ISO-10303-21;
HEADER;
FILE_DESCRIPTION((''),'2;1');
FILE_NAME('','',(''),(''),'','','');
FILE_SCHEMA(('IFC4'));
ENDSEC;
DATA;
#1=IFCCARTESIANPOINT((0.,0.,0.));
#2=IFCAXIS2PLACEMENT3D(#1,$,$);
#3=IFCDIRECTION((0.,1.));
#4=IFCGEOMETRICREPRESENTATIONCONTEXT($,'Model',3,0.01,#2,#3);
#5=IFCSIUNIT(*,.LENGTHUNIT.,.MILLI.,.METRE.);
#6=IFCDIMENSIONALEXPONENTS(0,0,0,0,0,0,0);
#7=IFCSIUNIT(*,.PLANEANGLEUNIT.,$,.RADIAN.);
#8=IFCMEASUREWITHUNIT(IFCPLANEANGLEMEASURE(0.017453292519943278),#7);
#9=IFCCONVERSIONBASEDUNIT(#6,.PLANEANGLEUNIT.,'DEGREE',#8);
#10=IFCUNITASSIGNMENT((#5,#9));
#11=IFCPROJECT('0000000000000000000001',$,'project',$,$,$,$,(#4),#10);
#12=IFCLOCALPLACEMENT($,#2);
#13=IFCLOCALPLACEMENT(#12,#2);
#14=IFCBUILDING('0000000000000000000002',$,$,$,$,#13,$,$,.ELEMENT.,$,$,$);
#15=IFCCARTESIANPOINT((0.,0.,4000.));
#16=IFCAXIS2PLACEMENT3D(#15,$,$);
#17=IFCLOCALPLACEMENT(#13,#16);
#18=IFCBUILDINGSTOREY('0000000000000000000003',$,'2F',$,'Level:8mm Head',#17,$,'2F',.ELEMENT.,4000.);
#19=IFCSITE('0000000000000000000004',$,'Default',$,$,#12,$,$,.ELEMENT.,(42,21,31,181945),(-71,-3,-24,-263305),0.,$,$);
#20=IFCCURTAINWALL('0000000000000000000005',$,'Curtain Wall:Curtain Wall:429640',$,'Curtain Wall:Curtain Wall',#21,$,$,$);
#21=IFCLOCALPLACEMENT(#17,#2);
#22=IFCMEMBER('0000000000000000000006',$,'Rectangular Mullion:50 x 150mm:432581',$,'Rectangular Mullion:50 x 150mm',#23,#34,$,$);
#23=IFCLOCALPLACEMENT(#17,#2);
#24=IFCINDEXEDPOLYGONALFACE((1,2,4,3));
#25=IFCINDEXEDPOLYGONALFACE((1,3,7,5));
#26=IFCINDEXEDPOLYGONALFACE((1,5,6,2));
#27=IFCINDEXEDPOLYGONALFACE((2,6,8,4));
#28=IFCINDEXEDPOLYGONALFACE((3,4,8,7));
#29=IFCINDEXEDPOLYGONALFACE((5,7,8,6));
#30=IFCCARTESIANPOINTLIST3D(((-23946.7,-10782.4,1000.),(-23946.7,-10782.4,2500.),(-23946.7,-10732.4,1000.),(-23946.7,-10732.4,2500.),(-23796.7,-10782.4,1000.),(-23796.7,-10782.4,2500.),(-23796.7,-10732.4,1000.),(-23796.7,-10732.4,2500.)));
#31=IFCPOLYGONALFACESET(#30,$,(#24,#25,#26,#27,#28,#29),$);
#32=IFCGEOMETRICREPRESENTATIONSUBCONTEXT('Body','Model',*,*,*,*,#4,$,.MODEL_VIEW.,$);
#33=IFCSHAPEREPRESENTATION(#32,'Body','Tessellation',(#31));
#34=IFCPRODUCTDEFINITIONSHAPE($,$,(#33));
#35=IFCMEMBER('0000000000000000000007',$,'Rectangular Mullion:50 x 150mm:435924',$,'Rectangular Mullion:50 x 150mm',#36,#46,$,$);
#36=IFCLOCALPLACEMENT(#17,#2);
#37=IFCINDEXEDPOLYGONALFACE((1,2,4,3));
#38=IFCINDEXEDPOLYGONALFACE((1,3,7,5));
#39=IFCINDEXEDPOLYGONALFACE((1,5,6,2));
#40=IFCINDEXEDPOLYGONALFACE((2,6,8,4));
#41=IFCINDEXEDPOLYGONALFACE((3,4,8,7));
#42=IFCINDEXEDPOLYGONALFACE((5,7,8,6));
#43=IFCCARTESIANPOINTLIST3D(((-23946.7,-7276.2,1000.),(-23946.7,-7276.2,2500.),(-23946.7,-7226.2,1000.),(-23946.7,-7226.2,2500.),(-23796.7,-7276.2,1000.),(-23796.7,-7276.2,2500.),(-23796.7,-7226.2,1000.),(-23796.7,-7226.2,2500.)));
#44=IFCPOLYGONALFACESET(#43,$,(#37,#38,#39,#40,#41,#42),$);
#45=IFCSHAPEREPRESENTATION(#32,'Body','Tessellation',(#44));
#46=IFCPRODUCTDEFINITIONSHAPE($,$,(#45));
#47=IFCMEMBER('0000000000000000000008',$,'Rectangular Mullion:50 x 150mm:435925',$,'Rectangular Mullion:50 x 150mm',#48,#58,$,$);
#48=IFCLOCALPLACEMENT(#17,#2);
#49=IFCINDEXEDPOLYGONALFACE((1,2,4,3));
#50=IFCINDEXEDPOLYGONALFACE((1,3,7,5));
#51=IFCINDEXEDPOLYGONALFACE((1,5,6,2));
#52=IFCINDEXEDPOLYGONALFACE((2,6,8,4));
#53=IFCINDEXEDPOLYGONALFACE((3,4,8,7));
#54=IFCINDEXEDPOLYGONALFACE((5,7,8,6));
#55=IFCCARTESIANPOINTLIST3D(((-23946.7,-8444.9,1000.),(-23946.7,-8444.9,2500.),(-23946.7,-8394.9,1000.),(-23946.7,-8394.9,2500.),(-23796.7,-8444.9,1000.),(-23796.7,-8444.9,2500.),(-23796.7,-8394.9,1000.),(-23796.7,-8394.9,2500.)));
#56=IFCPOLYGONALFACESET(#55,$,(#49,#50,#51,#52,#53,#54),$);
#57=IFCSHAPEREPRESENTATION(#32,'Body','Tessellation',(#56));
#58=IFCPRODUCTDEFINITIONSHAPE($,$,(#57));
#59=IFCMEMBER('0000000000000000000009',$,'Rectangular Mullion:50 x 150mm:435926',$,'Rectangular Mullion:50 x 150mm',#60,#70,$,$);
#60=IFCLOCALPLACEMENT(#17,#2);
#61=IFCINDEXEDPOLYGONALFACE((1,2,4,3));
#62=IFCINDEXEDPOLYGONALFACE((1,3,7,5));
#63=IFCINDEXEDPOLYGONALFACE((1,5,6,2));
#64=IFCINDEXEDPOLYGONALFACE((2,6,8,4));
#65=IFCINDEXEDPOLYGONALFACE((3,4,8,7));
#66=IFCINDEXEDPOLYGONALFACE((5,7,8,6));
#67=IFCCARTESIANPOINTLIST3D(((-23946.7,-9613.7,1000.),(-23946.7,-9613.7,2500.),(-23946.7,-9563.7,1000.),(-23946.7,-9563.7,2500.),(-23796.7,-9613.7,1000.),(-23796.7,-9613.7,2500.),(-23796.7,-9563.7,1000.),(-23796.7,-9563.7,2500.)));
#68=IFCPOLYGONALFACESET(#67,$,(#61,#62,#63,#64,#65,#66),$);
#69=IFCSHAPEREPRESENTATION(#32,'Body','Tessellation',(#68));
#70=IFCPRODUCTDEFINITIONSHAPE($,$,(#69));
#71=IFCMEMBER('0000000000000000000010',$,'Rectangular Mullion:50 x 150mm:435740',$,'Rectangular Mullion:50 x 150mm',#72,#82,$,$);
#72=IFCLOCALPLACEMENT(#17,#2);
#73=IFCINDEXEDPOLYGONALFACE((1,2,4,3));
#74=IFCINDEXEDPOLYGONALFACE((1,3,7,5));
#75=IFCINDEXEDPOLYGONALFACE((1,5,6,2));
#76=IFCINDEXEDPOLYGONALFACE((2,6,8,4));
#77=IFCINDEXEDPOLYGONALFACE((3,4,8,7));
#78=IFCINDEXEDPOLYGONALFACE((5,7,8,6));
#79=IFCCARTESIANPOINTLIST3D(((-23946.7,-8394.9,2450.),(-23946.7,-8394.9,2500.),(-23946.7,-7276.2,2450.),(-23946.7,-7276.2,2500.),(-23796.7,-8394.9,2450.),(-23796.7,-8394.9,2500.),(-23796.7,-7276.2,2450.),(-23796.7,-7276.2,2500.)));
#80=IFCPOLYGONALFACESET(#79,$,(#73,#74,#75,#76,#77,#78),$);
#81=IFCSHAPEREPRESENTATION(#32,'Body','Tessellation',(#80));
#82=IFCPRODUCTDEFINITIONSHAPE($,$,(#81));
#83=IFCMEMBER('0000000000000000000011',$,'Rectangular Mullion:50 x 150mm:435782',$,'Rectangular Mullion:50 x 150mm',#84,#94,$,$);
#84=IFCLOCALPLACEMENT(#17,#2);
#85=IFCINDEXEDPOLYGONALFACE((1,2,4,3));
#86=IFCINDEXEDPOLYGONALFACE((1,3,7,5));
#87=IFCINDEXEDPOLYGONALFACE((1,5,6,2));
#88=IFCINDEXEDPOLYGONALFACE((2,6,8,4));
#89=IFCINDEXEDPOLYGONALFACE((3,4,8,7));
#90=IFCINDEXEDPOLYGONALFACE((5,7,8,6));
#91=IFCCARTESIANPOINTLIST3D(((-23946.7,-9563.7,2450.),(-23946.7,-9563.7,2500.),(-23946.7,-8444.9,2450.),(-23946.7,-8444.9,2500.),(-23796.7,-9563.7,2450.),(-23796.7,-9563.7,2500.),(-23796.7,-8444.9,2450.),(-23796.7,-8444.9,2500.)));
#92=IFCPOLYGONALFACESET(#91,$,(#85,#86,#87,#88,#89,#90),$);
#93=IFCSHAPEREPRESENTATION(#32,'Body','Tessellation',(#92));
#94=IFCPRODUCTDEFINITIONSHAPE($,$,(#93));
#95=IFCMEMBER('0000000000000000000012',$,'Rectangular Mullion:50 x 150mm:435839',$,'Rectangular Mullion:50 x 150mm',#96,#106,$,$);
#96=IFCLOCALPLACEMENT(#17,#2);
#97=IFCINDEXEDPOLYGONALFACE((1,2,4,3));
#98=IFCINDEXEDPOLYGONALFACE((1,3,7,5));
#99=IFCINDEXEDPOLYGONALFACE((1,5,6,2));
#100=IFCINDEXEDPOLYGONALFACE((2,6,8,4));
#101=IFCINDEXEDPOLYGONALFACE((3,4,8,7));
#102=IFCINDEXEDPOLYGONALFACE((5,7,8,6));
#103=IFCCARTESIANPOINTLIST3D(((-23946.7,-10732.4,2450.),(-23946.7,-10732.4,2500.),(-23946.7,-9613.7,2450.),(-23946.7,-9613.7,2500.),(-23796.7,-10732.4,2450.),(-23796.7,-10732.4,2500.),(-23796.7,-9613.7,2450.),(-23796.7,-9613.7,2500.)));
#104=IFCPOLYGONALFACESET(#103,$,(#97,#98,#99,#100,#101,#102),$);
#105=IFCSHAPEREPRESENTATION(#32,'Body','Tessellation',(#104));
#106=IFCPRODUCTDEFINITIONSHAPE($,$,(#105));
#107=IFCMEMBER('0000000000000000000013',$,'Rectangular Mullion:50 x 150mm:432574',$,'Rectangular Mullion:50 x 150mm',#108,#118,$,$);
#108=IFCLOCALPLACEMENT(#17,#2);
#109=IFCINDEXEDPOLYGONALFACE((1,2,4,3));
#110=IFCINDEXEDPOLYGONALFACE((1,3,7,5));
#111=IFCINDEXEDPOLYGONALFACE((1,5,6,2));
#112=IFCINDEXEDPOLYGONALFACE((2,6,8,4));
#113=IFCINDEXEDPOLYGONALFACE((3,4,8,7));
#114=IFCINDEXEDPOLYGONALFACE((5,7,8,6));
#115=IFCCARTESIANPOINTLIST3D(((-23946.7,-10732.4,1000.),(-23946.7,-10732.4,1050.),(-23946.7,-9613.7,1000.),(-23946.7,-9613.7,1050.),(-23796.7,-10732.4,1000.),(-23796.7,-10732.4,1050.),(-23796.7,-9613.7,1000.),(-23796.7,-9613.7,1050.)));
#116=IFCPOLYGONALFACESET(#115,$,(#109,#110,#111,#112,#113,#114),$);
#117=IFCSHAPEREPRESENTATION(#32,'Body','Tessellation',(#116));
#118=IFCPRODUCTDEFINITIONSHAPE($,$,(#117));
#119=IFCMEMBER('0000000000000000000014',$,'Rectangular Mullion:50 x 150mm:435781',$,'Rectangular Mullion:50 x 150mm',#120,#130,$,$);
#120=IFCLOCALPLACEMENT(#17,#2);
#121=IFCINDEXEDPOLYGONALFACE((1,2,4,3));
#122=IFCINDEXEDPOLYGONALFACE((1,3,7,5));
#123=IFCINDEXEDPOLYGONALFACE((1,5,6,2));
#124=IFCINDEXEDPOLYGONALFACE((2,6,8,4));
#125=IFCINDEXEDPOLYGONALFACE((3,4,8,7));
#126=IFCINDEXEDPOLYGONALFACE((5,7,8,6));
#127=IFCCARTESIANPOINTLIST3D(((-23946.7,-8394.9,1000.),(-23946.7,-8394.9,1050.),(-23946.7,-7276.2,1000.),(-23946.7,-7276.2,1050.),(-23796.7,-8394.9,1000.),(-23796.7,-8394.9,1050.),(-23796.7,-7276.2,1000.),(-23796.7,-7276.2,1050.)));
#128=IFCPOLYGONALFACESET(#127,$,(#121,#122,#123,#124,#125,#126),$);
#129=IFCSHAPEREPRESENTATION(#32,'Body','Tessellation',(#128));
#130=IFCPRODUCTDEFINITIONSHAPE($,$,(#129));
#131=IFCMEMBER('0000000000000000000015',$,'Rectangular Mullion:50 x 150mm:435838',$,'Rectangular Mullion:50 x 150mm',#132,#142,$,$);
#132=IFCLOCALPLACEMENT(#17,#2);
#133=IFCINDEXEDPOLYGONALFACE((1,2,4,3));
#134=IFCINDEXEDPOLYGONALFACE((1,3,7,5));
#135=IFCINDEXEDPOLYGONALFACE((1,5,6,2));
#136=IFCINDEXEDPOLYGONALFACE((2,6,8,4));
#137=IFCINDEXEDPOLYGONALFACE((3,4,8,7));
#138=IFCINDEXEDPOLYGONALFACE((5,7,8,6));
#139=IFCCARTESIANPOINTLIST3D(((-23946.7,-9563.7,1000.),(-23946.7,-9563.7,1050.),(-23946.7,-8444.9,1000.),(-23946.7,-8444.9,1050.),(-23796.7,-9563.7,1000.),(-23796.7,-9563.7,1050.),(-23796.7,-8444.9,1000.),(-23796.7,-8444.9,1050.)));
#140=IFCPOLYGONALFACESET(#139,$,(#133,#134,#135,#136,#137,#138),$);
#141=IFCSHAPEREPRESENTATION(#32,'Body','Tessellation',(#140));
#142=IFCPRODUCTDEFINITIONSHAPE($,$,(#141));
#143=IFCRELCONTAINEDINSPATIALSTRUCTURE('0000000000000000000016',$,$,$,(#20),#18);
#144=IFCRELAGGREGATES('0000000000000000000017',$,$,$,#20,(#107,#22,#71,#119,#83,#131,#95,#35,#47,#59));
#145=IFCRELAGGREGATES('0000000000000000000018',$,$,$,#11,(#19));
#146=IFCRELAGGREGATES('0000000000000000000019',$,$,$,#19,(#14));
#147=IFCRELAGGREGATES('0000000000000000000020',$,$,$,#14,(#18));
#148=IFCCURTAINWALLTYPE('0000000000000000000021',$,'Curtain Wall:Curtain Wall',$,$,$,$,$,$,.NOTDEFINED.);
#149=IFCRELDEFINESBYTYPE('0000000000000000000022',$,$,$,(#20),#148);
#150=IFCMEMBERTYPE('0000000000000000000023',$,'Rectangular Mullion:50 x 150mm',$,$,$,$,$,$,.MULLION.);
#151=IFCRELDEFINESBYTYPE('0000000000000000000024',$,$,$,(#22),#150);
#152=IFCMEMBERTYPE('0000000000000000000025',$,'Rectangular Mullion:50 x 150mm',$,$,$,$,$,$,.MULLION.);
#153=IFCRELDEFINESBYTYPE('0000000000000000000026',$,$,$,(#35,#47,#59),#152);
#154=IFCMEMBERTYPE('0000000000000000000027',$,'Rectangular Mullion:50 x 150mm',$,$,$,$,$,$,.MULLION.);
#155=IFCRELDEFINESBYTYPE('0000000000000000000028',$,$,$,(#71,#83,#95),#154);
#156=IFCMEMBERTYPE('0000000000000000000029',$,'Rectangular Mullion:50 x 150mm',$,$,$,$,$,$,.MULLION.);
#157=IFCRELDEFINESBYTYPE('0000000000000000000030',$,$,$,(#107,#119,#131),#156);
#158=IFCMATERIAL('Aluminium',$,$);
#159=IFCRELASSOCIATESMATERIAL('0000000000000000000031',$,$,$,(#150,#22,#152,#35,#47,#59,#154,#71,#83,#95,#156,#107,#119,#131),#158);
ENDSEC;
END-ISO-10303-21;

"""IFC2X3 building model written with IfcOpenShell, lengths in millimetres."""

from ifc_helpers import new_model, entity, si_unit, converted_unit, direction, frame, origin, origin_2d_with_axis, place, context, subcontext, project, spatial, rectangle, extrude, source, transform, mapped, material, type_object, type_shapes, element, aggregate, save


model = new_model("IFC2X3")

# Units and contexts
model_context = context("Model", 3, precision=0.01, world=origin(), true_north=direction((0.0, 1.0)))
body_context = subcontext(model_context, "Body", "Model", "MODEL_VIEW")
ifc_project = project(units=[si_unit("LENGTHUNIT", "METRE", prefix="MILLI"), converted_unit("PLANEANGLEUNIT", "DEGREE", entity("IfcPlaneAngleMeasure", 0.017453292519943278), si_unit("PLANEANGLEUNIT", "RADIAN"), dimensions=[0, 0, 0, 0, 0, 0, 0])], contexts=[model_context])

# Site, building, storey
site_placement = place(None, origin())
site = spatial("IfcSite", under=ifc_project, at=site_placement, Name="Default", CompositionType="ELEMENT", RefLatitude=(42, 21, 31, 181945), RefLongitude=(-71, -3, -24, -263305), RefElevation=0.0)
building_placement = place(site_placement, origin())
building = spatial("IfcBuilding", under=site, at=building_placement, CompositionType="ELEMENT")
storey_placement = place(building_placement, frame((0.0, 0.0, 4000.0)))
storey = spatial("IfcBuildingStorey", under=building, at=storey_placement, Name="2F", ObjectType="Level:8mm Head", LongName="2F", CompositionType="ELEMENT", Elevation=4000.0)

# Curtain wall, members
curtain_wall_type = type_object("IfcCurtainWallType", Name="Curtain Wall:Curtain Wall", PredefinedType="NOTDEFINED")
curtain_wall_placement = place(storey_placement, frame((0.0, 0.0, -4000.0)))
curtain_wall = element("IfcCurtainWall", 1, at=curtain_wall_placement, inside=storey, type_object=curtain_wall_type, Name="Curtain Wall:Curtain Wall:429640", ObjectType="Curtain Wall:Curtain Wall")
ifc_material_1 = material(Name="Aluminium")
member_type_1 = type_object("IfcMemberType", Name="Rectangular Mullion:50 x 150mm", PredefinedType="MULLION", material=ifc_material_1)
shared_shape_1 = source(origin(), body_context, "Body", "SweptSolid", [
    extrude(rectangle(XDim=50.0, YDim=150.0, at=origin_2d_with_axis()), frame((-25.0, 0.0, -1500.0), z_axis=(0.0, 0.0, 1.0), x_axis=(-1.0, 0.0, 0.0)), (0.0, 0.0, 1.0), 1500.0),
])
type_shapes(member_type_1, [shared_shape_1])
member_1_placement = place(curtain_wall_placement, frame((-23871.7, -10782.4, 6500.0), z_axis=(0.0, 0.0, 1.0), x_axis=(0.0, -1.0, 0.0)))
member_1 = element("IfcMember", 2, at=member_1_placement, type_object=member_type_1, material=ifc_material_1, Name="Rectangular Mullion:50 x 150mm:432581", ObjectType="Rectangular Mullion:50 x 150mm", context=body_context, shape_type="MappedRepresentation", body=[
    mapped(shared_shape_1, transform((0.0, 0.0, 0.0), scale=1.0)),
])
member_type_2 = type_object("IfcMemberType", Name="Rectangular Mullion:50 x 150mm", PredefinedType="MULLION", material=ifc_material_1)
shared_shape_2 = source(origin(), body_context, "Body", "SweptSolid", [
    extrude(rectangle(XDim=50.0, YDim=150.0, at=origin_2d_with_axis()), frame((0.0, 0.0, -1500.0), z_axis=(0.0, 0.0, 1.0), x_axis=(-1.0, 0.0, 0.0)), (0.0, 0.0, 1.0), 1500.0),
])
type_shapes(member_type_2, [shared_shape_2])
member_2_placement = place(curtain_wall_placement, frame((-23871.7, -7251.2, 5000.0), z_axis=(0.0, 0.0, -1.0), x_axis=(0.0, 1.0, 0.0)))
member_2 = element("IfcMember", 3, at=member_2_placement, type_object=member_type_2, material=ifc_material_1, Name="Rectangular Mullion:50 x 150mm:435924", ObjectType="Rectangular Mullion:50 x 150mm", context=body_context, shape_type="MappedRepresentation", body=[
    mapped(shared_shape_2, transform((0.0, 0.0, 0.0), scale=1.0)),
])
member_3_placement = place(curtain_wall_placement, frame((-23871.7, -8419.9, 5000.0), z_axis=(0.0, 0.0, -1.0), x_axis=(0.0, 1.0, 0.0)))
member_3 = element("IfcMember", 4, at=member_3_placement, type_object=member_type_2, material=ifc_material_1, Name="Rectangular Mullion:50 x 150mm:435925", ObjectType="Rectangular Mullion:50 x 150mm", context=body_context, shape_type="MappedRepresentation", body=[
    mapped(shared_shape_2, transform((0.0, 0.0, 0.0), scale=1.0)),
])
member_4_placement = place(curtain_wall_placement, frame((-23871.7, -9588.7, 5000.0), z_axis=(0.0, 0.0, -1.0), x_axis=(0.0, 1.0, 0.0)))
member_4 = element("IfcMember", 5, at=member_4_placement, type_object=member_type_2, material=ifc_material_1, Name="Rectangular Mullion:50 x 150mm:435926", ObjectType="Rectangular Mullion:50 x 150mm", context=body_context, shape_type="MappedRepresentation", body=[
    mapped(shared_shape_2, transform((0.0, 0.0, 0.0), scale=1.0)),
])
member_type_3 = type_object("IfcMemberType", Name="Rectangular Mullion:50 x 150mm", PredefinedType="MULLION", material=ifc_material_1)
shared_shape_3 = source(origin(), body_context, "Body", "SweptSolid", [
    extrude(rectangle(XDim=50.0, YDim=150.0, at=origin_2d_with_axis()), frame((-25.0, 0.0, -1118.8), z_axis=(0.0, 0.0, 1.0), x_axis=(-1.0, 0.0, 0.0)), (0.0, 0.0, 1.0), 1118.8),
])
type_shapes(member_type_3, [shared_shape_3])
member_5_placement = place(curtain_wall_placement, frame((-23871.7, -7276.2, 6500.0), z_axis=(0.0, 1.0, 0.0), x_axis=(0.0, 0.0, 1.0)))
member_5 = element("IfcMember", 6, at=member_5_placement, type_object=member_type_3, material=ifc_material_1, Name="Rectangular Mullion:50 x 150mm:435740", ObjectType="Rectangular Mullion:50 x 150mm", context=body_context, shape_type="MappedRepresentation", body=[
    mapped(shared_shape_3, transform((0.0, 0.0, 0.0), scale=1.0)),
])
member_6_placement = place(curtain_wall_placement, frame((-23871.7, -8444.9, 6500.0), z_axis=(0.0, 1.0, 0.0), x_axis=(0.0, 0.0, 1.0)))
member_6 = element("IfcMember", 7, at=member_6_placement, type_object=member_type_3, material=ifc_material_1, Name="Rectangular Mullion:50 x 150mm:435782", ObjectType="Rectangular Mullion:50 x 150mm", context=body_context, shape_type="MappedRepresentation", body=[
    mapped(shared_shape_3, transform((0.0, 0.0, 0.0), scale=1.0)),
])
member_7_placement = place(curtain_wall_placement, frame((-23871.7, -9613.7, 6500.0), z_axis=(0.0, 1.0, 0.0), x_axis=(0.0, 0.0, 1.0)))
member_7 = element("IfcMember", 8, at=member_7_placement, type_object=member_type_3, material=ifc_material_1, Name="Rectangular Mullion:50 x 150mm:435839", ObjectType="Rectangular Mullion:50 x 150mm", context=body_context, shape_type="MappedRepresentation", body=[
    mapped(shared_shape_3, transform((0.0, 0.0, 0.0), scale=1.0)),
])
member_type_4 = type_object("IfcMemberType", Name="Rectangular Mullion:50 x 150mm", PredefinedType="MULLION", material=ifc_material_1)
shared_shape_4 = source(origin(), body_context, "Body", "SweptSolid", [
    extrude(rectangle(XDim=50.0, YDim=150.0, at=origin_2d_with_axis()), frame((-25.0, 0.0, -1118.8), z_axis=(0.0, 0.0, 1.0), x_axis=(-1.0, 0.0, 0.0)), (0.0, 0.0, 1.0), 1118.8),
])
type_shapes(member_type_4, [shared_shape_4])
member_8_placement = place(curtain_wall_placement, frame((-23871.7, -10732.4, 5000.0), z_axis=(0.0, -1.0, 0.0), x_axis=(0.0, 0.0, -1.0)))
member_8 = element("IfcMember", 9, at=member_8_placement, type_object=member_type_4, material=ifc_material_1, Name="Rectangular Mullion:50 x 150mm:432574", ObjectType="Rectangular Mullion:50 x 150mm", context=body_context, shape_type="MappedRepresentation", body=[
    mapped(shared_shape_4, transform((0.0, 0.0, 0.0), scale=1.0)),
])
member_9_placement = place(curtain_wall_placement, frame((-23871.7, -8394.9, 5000.0), z_axis=(0.0, -1.0, 0.0), x_axis=(0.0, 0.0, -1.0)))
member_9 = element("IfcMember", 10, at=member_9_placement, type_object=member_type_4, material=ifc_material_1, Name="Rectangular Mullion:50 x 150mm:435781", ObjectType="Rectangular Mullion:50 x 150mm", context=body_context, shape_type="MappedRepresentation", body=[
    mapped(shared_shape_4, transform((0.0, 0.0, 0.0), scale=1.0)),
])
member_10_placement = place(curtain_wall_placement, frame((-23871.7, -9563.7, 5000.0), z_axis=(0.0, -1.0, 0.0), x_axis=(0.0, 0.0, -1.0)))
member_10 = element("IfcMember", 11, at=member_10_placement, type_object=member_type_4, material=ifc_material_1, Name="Rectangular Mullion:50 x 150mm:435838", ObjectType="Rectangular Mullion:50 x 150mm", context=body_context, shape_type="MappedRepresentation", body=[
    mapped(shared_shape_4, transform((0.0, 0.0, 0.0), scale=1.0)),
])

aggregate(curtain_wall, [member_8, member_1, member_5, member_9, member_6, member_10, member_7, member_2, member_3, member_4])

save(model, "model.ifc")
